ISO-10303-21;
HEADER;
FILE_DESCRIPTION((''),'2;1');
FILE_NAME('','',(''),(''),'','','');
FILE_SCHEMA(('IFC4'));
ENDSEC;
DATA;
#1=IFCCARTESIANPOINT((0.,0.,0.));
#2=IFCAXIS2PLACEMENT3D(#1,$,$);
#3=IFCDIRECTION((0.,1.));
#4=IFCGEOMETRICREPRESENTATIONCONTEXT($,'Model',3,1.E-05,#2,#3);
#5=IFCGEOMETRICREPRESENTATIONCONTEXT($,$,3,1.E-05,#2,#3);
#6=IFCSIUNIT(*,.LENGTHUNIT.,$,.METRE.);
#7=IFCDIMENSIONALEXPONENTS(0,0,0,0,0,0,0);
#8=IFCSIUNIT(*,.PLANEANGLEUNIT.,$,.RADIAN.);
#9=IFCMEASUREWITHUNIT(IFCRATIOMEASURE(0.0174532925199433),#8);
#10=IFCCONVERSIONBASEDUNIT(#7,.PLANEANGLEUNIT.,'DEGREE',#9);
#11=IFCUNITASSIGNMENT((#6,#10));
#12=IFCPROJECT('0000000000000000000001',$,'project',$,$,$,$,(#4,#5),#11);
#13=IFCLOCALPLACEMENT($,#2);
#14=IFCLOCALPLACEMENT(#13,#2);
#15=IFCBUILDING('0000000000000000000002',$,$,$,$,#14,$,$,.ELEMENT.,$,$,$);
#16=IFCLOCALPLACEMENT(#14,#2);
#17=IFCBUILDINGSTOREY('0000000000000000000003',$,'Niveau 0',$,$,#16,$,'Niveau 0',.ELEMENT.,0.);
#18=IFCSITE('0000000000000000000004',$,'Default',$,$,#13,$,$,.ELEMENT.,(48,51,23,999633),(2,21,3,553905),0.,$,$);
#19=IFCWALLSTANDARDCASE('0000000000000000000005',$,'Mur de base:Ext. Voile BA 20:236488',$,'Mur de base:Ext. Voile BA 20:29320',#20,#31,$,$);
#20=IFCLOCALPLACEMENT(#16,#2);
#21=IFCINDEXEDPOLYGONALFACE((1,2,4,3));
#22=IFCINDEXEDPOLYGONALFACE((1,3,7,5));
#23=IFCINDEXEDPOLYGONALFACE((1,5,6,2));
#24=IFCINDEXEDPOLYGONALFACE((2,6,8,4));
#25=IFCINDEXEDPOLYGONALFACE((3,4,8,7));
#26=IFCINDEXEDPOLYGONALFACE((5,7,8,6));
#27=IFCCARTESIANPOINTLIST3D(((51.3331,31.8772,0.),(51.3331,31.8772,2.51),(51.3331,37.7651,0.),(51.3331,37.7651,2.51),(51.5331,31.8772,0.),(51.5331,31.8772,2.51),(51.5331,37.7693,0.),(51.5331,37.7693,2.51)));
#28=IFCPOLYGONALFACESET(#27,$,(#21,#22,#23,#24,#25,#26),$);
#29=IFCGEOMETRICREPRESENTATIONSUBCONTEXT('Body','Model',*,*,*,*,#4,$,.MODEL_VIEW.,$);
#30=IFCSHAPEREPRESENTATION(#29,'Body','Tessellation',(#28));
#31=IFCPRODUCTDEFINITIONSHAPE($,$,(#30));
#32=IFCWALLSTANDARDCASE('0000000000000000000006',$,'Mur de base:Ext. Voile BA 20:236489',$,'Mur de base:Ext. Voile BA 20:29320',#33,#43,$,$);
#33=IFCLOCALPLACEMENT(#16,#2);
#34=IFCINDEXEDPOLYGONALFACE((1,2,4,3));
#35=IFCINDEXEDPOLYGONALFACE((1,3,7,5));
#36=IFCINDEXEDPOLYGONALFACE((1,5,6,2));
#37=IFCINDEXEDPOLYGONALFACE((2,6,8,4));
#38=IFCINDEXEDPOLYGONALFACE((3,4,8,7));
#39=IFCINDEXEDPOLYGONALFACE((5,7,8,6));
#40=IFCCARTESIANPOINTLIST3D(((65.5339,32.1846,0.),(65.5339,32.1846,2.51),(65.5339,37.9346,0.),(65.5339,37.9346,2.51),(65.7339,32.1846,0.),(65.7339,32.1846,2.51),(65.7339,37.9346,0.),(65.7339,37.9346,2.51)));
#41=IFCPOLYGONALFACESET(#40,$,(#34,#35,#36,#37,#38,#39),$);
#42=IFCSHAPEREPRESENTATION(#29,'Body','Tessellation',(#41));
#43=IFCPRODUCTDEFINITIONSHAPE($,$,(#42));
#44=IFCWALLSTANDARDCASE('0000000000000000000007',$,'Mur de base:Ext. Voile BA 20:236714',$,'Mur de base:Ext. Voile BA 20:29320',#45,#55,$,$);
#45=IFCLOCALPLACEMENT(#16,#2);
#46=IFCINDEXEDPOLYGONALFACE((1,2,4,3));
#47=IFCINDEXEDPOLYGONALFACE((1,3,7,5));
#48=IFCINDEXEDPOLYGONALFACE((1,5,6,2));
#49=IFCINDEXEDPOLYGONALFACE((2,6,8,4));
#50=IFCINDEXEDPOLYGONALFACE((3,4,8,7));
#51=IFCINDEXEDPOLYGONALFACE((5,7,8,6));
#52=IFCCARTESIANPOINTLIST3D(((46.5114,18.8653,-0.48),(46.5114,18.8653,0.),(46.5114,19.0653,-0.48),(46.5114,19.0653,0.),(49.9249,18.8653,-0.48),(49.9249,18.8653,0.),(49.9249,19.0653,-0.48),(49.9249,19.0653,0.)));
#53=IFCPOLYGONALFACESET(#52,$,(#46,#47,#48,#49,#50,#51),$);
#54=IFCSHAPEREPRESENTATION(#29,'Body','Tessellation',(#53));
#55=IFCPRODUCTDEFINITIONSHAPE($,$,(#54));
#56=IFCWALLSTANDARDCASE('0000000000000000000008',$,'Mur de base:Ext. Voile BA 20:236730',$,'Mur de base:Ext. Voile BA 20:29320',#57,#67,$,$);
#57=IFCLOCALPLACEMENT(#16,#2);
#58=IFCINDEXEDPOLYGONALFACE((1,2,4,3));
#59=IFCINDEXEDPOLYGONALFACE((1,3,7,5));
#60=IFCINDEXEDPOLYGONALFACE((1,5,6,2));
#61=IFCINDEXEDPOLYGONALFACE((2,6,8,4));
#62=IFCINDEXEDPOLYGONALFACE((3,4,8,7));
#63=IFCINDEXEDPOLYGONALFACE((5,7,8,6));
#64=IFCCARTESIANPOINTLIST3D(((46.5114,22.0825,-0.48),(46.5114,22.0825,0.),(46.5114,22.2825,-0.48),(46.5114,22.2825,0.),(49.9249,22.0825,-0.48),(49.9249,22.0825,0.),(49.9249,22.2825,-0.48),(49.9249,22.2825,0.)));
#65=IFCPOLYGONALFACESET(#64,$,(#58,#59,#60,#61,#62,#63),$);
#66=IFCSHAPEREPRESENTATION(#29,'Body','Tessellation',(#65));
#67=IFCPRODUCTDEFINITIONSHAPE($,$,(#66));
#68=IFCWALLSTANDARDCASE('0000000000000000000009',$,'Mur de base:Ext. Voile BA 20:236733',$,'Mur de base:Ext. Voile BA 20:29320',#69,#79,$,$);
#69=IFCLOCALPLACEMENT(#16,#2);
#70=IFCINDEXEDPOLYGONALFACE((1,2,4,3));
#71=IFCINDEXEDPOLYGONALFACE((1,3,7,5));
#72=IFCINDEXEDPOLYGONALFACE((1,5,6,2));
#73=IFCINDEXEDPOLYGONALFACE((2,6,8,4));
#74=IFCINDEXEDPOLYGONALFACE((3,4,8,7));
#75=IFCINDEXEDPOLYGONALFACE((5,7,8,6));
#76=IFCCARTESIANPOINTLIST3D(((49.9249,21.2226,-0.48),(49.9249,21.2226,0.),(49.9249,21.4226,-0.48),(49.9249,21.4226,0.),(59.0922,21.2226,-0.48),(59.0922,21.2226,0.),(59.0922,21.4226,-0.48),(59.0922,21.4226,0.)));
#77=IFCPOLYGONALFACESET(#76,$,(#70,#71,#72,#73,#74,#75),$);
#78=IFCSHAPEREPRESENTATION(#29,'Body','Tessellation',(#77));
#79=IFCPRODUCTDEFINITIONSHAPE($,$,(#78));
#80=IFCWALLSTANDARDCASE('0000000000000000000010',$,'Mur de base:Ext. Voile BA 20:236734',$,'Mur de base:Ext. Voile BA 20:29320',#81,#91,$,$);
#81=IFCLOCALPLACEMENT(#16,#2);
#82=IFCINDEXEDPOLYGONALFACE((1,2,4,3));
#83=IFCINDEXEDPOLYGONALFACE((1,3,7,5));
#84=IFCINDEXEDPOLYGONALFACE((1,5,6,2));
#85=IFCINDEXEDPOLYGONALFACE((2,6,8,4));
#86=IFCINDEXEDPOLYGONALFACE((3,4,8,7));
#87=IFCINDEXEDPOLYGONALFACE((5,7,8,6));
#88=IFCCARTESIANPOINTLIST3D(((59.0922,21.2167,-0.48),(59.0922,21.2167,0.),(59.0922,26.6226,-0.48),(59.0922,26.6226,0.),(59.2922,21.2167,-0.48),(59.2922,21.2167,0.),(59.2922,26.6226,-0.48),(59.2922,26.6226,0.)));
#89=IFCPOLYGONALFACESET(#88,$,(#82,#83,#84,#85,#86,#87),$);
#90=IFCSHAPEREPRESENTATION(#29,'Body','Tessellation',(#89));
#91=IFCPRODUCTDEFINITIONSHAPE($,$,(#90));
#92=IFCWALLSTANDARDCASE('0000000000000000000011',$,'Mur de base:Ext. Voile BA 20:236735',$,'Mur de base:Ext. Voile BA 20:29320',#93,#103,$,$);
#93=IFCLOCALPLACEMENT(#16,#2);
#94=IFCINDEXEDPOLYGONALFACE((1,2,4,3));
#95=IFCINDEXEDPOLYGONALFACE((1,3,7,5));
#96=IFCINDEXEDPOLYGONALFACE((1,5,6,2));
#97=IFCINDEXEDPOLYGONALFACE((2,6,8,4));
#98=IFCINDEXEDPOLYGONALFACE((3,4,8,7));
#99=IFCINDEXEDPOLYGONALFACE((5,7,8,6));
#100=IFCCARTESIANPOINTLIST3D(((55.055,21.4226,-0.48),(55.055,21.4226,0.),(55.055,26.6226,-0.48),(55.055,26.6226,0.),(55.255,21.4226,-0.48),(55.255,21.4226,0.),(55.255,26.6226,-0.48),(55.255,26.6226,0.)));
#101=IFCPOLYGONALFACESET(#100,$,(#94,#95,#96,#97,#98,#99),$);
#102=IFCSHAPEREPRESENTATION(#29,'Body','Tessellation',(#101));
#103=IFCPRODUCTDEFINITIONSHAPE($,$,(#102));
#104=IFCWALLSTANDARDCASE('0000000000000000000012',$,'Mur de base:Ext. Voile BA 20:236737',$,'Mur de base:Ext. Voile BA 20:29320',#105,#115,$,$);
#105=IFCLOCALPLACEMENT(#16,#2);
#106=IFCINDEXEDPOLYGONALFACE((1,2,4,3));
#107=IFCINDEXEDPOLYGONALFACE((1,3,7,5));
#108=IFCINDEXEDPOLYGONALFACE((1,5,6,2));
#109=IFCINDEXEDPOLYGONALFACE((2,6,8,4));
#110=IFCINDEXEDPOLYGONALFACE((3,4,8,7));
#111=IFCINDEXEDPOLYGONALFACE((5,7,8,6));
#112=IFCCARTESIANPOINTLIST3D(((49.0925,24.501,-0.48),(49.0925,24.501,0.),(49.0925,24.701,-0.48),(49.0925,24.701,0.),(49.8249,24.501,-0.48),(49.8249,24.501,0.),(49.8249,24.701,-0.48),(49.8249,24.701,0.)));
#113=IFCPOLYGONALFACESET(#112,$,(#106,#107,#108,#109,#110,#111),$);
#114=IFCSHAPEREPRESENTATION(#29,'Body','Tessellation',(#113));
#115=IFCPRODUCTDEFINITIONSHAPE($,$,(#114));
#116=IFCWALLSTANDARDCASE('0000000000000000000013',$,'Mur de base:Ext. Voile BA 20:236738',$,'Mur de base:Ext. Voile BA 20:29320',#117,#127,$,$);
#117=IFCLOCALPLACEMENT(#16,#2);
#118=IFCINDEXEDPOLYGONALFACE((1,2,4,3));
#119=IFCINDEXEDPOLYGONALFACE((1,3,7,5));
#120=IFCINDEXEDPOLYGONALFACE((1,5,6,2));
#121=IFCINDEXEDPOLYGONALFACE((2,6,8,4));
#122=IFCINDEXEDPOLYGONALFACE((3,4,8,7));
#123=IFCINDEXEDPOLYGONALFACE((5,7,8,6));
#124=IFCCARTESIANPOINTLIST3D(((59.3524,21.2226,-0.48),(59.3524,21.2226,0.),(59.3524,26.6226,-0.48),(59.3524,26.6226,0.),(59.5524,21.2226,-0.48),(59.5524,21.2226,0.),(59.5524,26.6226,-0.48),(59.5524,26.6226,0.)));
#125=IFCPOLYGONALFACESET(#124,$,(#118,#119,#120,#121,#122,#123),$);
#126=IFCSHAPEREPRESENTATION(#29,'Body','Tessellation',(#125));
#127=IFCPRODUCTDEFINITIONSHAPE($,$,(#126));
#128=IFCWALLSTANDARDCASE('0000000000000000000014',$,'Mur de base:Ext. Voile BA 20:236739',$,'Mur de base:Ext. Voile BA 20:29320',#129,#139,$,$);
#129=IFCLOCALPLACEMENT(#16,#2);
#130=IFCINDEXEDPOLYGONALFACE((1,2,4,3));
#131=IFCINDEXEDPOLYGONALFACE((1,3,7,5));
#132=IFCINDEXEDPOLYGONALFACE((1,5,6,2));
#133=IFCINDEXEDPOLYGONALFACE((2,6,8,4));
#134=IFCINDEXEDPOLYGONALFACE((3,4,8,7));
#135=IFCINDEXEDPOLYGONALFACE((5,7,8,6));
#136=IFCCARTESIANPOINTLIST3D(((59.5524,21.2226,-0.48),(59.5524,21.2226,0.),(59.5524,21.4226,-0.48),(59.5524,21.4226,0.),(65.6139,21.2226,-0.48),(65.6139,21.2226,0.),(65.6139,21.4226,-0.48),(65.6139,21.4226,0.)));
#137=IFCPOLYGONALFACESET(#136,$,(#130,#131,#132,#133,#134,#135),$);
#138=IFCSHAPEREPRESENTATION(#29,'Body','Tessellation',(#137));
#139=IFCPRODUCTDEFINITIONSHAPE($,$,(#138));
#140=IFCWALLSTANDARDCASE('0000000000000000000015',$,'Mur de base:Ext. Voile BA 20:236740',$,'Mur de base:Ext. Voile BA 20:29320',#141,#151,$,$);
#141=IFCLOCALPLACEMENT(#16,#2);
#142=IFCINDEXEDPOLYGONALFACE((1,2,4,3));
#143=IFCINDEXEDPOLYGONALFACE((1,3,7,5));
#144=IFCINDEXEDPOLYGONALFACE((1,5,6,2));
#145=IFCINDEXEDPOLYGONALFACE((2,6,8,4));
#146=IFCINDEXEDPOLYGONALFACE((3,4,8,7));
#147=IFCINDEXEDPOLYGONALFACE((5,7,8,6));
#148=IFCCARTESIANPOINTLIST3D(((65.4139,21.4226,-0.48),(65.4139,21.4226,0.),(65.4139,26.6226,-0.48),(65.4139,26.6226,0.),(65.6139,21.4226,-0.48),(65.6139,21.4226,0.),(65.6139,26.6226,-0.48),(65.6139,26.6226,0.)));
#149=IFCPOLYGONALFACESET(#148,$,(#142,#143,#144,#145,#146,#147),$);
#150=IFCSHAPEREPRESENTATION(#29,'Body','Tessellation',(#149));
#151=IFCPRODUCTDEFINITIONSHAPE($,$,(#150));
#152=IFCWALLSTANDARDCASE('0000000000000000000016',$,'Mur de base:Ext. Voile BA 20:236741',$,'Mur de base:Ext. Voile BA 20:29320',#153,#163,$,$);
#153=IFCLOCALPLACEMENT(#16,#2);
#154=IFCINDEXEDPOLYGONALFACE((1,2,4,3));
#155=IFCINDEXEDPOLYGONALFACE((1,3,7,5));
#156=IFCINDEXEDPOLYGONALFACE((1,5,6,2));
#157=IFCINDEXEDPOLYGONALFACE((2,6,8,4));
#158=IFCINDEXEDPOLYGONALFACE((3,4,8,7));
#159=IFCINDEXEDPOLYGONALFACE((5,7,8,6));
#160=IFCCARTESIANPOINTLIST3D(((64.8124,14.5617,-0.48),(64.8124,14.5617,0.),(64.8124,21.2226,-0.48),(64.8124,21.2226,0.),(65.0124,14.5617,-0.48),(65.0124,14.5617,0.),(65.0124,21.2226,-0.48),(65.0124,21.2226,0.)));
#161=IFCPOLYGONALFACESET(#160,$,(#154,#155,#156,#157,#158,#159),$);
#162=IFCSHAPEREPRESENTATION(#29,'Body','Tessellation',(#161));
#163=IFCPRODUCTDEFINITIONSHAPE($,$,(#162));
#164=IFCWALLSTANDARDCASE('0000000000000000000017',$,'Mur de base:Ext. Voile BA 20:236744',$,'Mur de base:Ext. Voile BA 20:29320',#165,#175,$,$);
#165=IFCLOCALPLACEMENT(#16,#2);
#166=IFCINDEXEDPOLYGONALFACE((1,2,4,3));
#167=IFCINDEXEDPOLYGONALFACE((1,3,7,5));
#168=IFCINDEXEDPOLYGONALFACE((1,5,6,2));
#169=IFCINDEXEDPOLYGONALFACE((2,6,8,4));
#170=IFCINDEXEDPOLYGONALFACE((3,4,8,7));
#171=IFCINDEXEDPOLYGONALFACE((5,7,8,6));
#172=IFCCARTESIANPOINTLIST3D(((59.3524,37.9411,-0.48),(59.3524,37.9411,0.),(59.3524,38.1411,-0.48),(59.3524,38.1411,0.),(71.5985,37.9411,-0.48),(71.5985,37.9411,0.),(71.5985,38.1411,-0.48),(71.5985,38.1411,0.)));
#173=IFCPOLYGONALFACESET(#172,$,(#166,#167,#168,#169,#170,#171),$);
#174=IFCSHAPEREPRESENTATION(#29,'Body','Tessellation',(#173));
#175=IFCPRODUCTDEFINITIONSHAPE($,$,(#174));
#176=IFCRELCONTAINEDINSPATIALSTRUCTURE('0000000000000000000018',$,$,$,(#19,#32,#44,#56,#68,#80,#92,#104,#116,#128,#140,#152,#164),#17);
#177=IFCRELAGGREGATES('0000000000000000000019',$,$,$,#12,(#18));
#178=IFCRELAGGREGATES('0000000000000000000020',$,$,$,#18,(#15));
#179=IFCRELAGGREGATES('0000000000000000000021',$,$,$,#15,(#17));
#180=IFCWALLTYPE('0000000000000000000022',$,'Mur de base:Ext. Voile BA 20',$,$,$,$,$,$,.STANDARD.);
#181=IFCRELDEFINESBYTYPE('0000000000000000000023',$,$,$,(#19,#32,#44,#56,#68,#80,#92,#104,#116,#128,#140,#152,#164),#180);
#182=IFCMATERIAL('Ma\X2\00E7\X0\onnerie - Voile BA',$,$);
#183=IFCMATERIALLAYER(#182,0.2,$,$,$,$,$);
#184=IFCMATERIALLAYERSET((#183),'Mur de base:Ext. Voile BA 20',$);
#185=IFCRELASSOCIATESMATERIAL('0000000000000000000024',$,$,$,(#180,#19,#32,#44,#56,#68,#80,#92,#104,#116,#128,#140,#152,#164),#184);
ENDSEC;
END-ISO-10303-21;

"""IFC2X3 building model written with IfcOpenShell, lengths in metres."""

from ifc_helpers import new_model, entity, si_unit, converted_unit, direction, frame, frame_2d, origin, place, context, subcontext, project, spatial, polyline, rectangle, outline, extrude, material, layer, layer_set, layer_usage, type_object, element, save


model = new_model("IFC2X3")

# Units and contexts
model_context = context("Model", 3, precision=1e-05, world=origin(), true_north=direction((0.0, 1.0)))
context_of_model = context(None, 3, precision=1e-05, world=origin(), true_north=direction((0.0, 1.0)))
body_context = subcontext(model_context, "Body", "Model", "MODEL_VIEW")
ifc_project = project(units=[si_unit("LENGTHUNIT", "METRE"), converted_unit("PLANEANGLEUNIT", "DEGREE", entity("IfcRatioMeasure", 0.0174532925199433), si_unit("PLANEANGLEUNIT", "RADIAN"), dimensions=[0, 0, 0, 0, 0, 0, 0])], contexts=[model_context, context_of_model])

# Site, building, storey
site_placement = place(None, origin())
site = spatial("IfcSite", under=ifc_project, at=site_placement, Name="Default", CompositionType="ELEMENT", RefLatitude=(48, 51, 23, 999633), RefLongitude=(2, 21, 3, 553905), RefElevation=0.0)
building_placement = place(site_placement, origin())
building = spatial("IfcBuilding", under=site, at=building_placement, CompositionType="ELEMENT")
storey_placement = place(building_placement, origin())
storey = spatial("IfcBuildingStorey", under=building, at=storey_placement, Name="Niveau 0", LongName="Niveau 0", CompositionType="ELEMENT", Elevation=0.0)

# Walls
ifc_material_1 = material(Name="Maçonnerie - Voile BA")
ifc_layer = layer(ifc_material_1, 0.2)
ifc_layer_set = layer_set([ifc_layer], Name="Mur de base:Ext. Voile BA 20")
wall_type = type_object("IfcWallType", Name="Mur de base:Ext. Voile BA 20", PredefinedType="STANDARD", material=ifc_layer_set)
ifc_layer_usage_1 = layer_usage(ifc_layer_set, "AXIS2", "NEGATIVE", 0.1)
wall_1_placement = place(storey_placement, frame((51.4331, 37.7693, 0.0), z_axis=(0.0, 0.0, 1.0), x_axis=(0.0, -1.0, 0.0)))
element("IfcWallStandardCase", 1, at=wall_1_placement, inside=storey, type_object=wall_type, material=ifc_layer_usage_1, Name="Mur de base:Ext. Voile BA 20:236488", ObjectType="Mur de base:Ext. Voile BA 20:29320", context=body_context, shape_type="SweptSolid", body=[
    extrude(outline(polyline([(5.8921, -0.1), (5.8921, 0.1), (0.0, 0.1), (0.0042, -0.1), (5.8921, -0.1)])), origin(), (0.0, 0.0, 1.0), 2.51),
])
ifc_layer_usage_2 = layer_usage(ifc_layer_set, "AXIS2", "NEGATIVE", 0.1)
wall_2_placement = place(storey_placement, frame((65.6339, 37.9346, 0.0), z_axis=(0.0, 0.0, 1.0), x_axis=(0.0, -1.0, 0.0)))
element("IfcWallStandardCase", 2, at=wall_2_placement, inside=storey, type_object=wall_type, material=ifc_layer_usage_2, Name="Mur de base:Ext. Voile BA 20:236489", ObjectType="Mur de base:Ext. Voile BA 20:29320", context=body_context, shape_type="SweptSolid", body=[
    extrude(rectangle(XDim=5.75, YDim=0.2, at=frame_2d((2.875, 0.0), x_axis=(-1.0, 0.0))), origin(), (0.0, 0.0, 1.0), 2.51),
])
ifc_layer_usage_3 = layer_usage(ifc_layer_set, "AXIS2", "NEGATIVE", 0.1)
wall_3_placement = place(storey_placement, frame((49.9249, 18.9653, -0.48), z_axis=(0.0, 0.0, 1.0), x_axis=(-1.0, 0.0, 0.0)))
element("IfcWallStandardCase", 3, at=wall_3_placement, inside=storey, type_object=wall_type, material=ifc_layer_usage_3, Name="Mur de base:Ext. Voile BA 20:236714", ObjectType="Mur de base:Ext. Voile BA 20:29320", context=body_context, shape_type="SweptSolid", body=[
    extrude(rectangle(XDim=3.4136, YDim=0.2, at=frame_2d((1.7068, 0.0), x_axis=(-1.0, 0.0))), origin(), (0.0, 0.0, 1.0), 0.48),
])
ifc_layer_usage_4 = layer_usage(ifc_layer_set, "AXIS2", "NEGATIVE", 0.1)
wall_4_placement = place(storey_placement, frame((49.9249, 22.1825, -0.48), z_axis=(0.0, 0.0, 1.0), x_axis=(-1.0, 0.0, 0.0)))
element("IfcWallStandardCase", 4, at=wall_4_placement, inside=storey, type_object=wall_type, material=ifc_layer_usage_4, Name="Mur de base:Ext. Voile BA 20:236730", ObjectType="Mur de base:Ext. Voile BA 20:29320", context=body_context, shape_type="SweptSolid", body=[
    extrude(rectangle(XDim=3.4136, YDim=0.2, at=frame_2d((1.7068, 0.0), x_axis=(-1.0, 0.0))), origin(), (0.0, 0.0, 1.0), 0.48),
])
ifc_layer_usage_5 = layer_usage(ifc_layer_set, "AXIS2", "NEGATIVE", 0.1)
wall_5_placement = place(storey_placement, frame((49.9249, 21.3226, -0.48)))
element("IfcWallStandardCase", 5, at=wall_5_placement, inside=storey, type_object=wall_type, material=ifc_layer_usage_5, Name="Mur de base:Ext. Voile BA 20:236733", ObjectType="Mur de base:Ext. Voile BA 20:29320", context=body_context, shape_type="SweptSolid", body=[
    extrude(rectangle(XDim=9.1673, YDim=0.2, at=frame_2d((4.5837, 0.0), x_axis=(-1.0, 0.0))), origin(), (0.0, 0.0, 1.0), 0.48),
])
ifc_layer_usage_6 = layer_usage(ifc_layer_set, "AXIS2", "NEGATIVE", 0.1)
wall_6_placement = place(storey_placement, frame((59.1922, 21.2167, -0.48), z_axis=(0.0, 0.0, 1.0), x_axis=(0.0, 1.0, 0.0)))
element("IfcWallStandardCase", 6, at=wall_6_placement, inside=storey, type_object=wall_type, material=ifc_layer_usage_6, Name="Mur de base:Ext. Voile BA 20:236734", ObjectType="Mur de base:Ext. Voile BA 20:29320", context=body_context, shape_type="SweptSolid", body=[
    extrude(rectangle(XDim=5.4059, YDim=0.2, at=frame_2d((2.703, 0.0), x_axis=(-1.0, 0.0))), origin(), (0.0, 0.0, 1.0), 0.48),
])
ifc_layer_usage_7 = layer_usage(ifc_layer_set, "AXIS2", "NEGATIVE", 0.1)
wall_7_placement = place(storey_placement, frame((55.155, 26.6226, -0.48), z_axis=(0.0, 0.0, 1.0), x_axis=(0.0, -1.0, 0.0)))
element("IfcWallStandardCase", 7, at=wall_7_placement, inside=storey, type_object=wall_type, material=ifc_layer_usage_7, Name="Mur de base:Ext. Voile BA 20:236735", ObjectType="Mur de base:Ext. Voile BA 20:29320", context=body_context, shape_type="SweptSolid", body=[
    extrude(rectangle(XDim=5.2, YDim=0.2, at=frame_2d((2.6, 0.0), x_axis=(-1.0, 0.0))), origin(), (0.0, 0.0, 1.0), 0.48),
])
ifc_layer_usage_8 = layer_usage(ifc_layer_set, "AXIS2", "NEGATIVE", 0.1)
wall_8_placement = place(storey_placement, frame((49.8249, 24.601, -0.48), z_axis=(0.0, 0.0, 1.0), x_axis=(-1.0, 0.0, 0.0)))
element("IfcWallStandardCase", 8, at=wall_8_placement, inside=storey, type_object=wall_type, material=ifc_layer_usage_8, Name="Mur de base:Ext. Voile BA 20:236737", ObjectType="Mur de base:Ext. Voile BA 20:29320", context=body_context, shape_type="SweptSolid", body=[
    extrude(rectangle(XDim=0.7324, YDim=0.2, at=frame_2d((0.3662, 0.0), x_axis=(-1.0, 0.0))), origin(), (0.0, 0.0, 1.0), 0.48),
])
ifc_layer_usage_9 = layer_usage(ifc_layer_set, "AXIS2", "NEGATIVE", 0.1)
wall_9_placement = place(storey_placement, frame((59.4524, 26.6226, -0.48), z_axis=(0.0, 0.0, 1.0), x_axis=(0.0, -1.0, 0.0)))
element("IfcWallStandardCase", 9, at=wall_9_placement, inside=storey, type_object=wall_type, material=ifc_layer_usage_9, Name="Mur de base:Ext. Voile BA 20:236738", ObjectType="Mur de base:Ext. Voile BA 20:29320", context=body_context, shape_type="SweptSolid", body=[
    extrude(rectangle(XDim=5.4, YDim=0.2, at=frame_2d((2.7, 0.0), x_axis=(-1.0, 0.0))), origin(), (0.0, 0.0, 1.0), 0.48),
])
ifc_layer_usage_10 = layer_usage(ifc_layer_set, "AXIS2", "NEGATIVE", 0.1)
wall_10_placement = place(storey_placement, frame((59.5524, 21.3226, -0.48)))
element("IfcWallStandardCase", 10, at=wall_10_placement, inside=storey, type_object=wall_type, material=ifc_layer_usage_10, Name="Mur de base:Ext. Voile BA 20:236739", ObjectType="Mur de base:Ext. Voile BA 20:29320", context=body_context, shape_type="SweptSolid", body=[
    extrude(rectangle(XDim=6.0615, YDim=0.2, at=frame_2d((3.0307, 0.0), x_axis=(-1.0, 0.0))), origin(), (0.0, 0.0, 1.0), 0.48),
])
ifc_layer_usage_11 = layer_usage(ifc_layer_set, "AXIS2", "NEGATIVE", 0.1)
wall_11_placement = place(storey_placement, frame((65.5139, 21.4226, -0.48), z_axis=(0.0, 0.0, 1.0), x_axis=(0.0, 1.0, 0.0)))
element("IfcWallStandardCase", 11, at=wall_11_placement, inside=storey, type_object=wall_type, material=ifc_layer_usage_11, Name="Mur de base:Ext. Voile BA 20:236740", ObjectType="Mur de base:Ext. Voile BA 20:29320", context=body_context, shape_type="SweptSolid", body=[
    extrude(rectangle(XDim=5.2, YDim=0.2, at=frame_2d((2.6, 0.0), x_axis=(-1.0, 0.0))), origin(), (0.0, 0.0, 1.0), 0.48),
])
ifc_layer_usage_12 = layer_usage(ifc_layer_set, "AXIS2", "NEGATIVE", 0.1)
wall_12_placement = place(storey_placement, frame((64.9124, 21.2226, -0.48), z_axis=(0.0, 0.0, 1.0), x_axis=(0.0, -1.0, 0.0)))
element("IfcWallStandardCase", 12, at=wall_12_placement, inside=storey, type_object=wall_type, material=ifc_layer_usage_12, Name="Mur de base:Ext. Voile BA 20:236741", ObjectType="Mur de base:Ext. Voile BA 20:29320", context=body_context, shape_type="SweptSolid", body=[
    extrude(rectangle(XDim=6.6609, YDim=0.2, at=frame_2d((3.3305, 0.0), x_axis=(-1.0, 0.0))), origin(), (0.0, 0.0, 1.0), 0.48),
])
ifc_layer_usage_13 = layer_usage(ifc_layer_set, "AXIS2", "NEGATIVE", 0.1)
wall_13_placement = place(storey_placement, frame((71.5985, 38.0411, -0.48), z_axis=(0.0, 0.0, 1.0), x_axis=(-1.0, 0.0, 0.0)))
element("IfcWallStandardCase", 13, at=wall_13_placement, inside=storey, type_object=wall_type, material=ifc_layer_usage_13, Name="Mur de base:Ext. Voile BA 20:236744", ObjectType="Mur de base:Ext. Voile BA 20:29320", context=body_context, shape_type="SweptSolid", body=[
    extrude(rectangle(XDim=12.2461, YDim=0.2, at=frame_2d((6.1231, 0.0), x_axis=(-1.0, 0.0))), origin(), (0.0, 0.0, 1.0), 0.48),
])

save(model, "model.ifc")
